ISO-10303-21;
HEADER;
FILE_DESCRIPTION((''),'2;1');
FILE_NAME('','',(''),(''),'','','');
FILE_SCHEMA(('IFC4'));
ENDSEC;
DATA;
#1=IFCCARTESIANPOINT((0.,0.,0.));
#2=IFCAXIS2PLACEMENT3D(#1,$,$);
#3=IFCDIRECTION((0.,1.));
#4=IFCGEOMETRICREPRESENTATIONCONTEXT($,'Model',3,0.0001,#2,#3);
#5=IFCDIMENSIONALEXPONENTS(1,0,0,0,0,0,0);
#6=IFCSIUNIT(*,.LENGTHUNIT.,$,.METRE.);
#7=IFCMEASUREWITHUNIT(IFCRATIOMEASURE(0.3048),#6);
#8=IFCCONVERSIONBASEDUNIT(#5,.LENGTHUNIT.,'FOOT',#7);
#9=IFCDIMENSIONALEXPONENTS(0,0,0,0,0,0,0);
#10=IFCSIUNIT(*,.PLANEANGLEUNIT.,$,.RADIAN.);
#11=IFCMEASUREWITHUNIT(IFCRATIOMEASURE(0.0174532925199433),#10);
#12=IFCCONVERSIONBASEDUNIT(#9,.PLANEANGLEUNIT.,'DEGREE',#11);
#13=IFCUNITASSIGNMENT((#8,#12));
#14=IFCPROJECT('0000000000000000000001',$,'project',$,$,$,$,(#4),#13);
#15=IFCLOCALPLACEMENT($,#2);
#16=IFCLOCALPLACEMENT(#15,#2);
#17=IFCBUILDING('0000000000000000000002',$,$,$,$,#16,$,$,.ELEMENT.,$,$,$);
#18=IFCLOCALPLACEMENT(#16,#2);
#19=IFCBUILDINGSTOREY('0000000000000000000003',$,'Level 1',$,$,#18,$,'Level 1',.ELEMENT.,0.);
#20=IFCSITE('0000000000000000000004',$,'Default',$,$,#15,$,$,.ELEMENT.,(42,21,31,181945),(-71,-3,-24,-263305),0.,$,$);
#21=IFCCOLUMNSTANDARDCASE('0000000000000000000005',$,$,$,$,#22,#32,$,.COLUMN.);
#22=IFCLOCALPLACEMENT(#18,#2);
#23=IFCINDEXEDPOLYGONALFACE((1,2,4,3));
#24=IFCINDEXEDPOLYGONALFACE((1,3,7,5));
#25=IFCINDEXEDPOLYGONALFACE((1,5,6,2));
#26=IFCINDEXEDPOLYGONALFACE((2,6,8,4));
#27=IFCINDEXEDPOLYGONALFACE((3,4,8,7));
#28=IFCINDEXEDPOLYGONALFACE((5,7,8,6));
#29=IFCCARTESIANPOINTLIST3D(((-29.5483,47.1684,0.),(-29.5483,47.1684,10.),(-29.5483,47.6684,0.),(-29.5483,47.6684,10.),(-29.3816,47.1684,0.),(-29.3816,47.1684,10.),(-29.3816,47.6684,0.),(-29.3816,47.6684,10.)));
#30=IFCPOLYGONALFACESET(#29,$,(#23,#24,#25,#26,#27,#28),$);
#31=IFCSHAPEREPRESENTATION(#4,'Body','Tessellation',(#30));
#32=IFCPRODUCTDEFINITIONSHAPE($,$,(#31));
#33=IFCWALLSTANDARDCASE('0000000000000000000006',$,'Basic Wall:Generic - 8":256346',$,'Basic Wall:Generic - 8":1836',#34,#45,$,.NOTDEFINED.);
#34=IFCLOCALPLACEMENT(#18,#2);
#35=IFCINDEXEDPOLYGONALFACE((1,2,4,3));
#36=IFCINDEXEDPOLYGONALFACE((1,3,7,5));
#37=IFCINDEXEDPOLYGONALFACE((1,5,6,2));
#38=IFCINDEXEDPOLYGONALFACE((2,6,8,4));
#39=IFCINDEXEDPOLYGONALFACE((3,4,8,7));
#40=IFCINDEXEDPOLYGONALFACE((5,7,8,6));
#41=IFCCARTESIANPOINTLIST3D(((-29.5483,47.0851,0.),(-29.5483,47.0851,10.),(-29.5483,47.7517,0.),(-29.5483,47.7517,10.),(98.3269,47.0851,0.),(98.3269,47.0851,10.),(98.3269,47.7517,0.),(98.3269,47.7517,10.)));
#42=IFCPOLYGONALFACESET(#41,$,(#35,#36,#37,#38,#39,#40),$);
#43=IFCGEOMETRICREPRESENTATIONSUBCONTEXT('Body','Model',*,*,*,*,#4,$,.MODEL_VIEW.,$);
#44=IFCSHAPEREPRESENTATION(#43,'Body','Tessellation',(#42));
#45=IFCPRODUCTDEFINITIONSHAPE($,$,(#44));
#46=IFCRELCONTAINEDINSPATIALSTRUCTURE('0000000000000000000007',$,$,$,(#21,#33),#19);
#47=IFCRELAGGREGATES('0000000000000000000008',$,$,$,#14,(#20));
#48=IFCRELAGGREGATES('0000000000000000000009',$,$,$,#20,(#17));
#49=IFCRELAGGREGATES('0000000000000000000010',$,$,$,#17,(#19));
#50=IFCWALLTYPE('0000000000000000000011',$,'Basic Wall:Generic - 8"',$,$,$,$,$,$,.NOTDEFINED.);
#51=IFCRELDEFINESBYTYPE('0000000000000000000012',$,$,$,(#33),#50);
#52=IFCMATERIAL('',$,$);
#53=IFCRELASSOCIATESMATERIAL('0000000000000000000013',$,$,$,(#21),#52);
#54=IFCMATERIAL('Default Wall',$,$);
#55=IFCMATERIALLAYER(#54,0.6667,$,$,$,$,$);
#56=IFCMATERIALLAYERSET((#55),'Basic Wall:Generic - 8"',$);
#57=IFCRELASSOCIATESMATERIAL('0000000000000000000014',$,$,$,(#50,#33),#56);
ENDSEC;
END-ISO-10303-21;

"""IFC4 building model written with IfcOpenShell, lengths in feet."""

from ifc_helpers import new_model, entity, si_unit, converted_unit, direction, frame, frame_2d, origin, place, context, subcontext, project, spatial, rectangle, extrude, material, layer, layer_set, layer_usage, type_object, element, save


model = new_model("IFC4")

# Units and contexts
model_context = context("Model", 3, precision=0.0001, world=origin(), true_north=direction((0.0, 1.0)))
body_context = subcontext(model_context, "Body", "Model", "MODEL_VIEW")
ifc_project = project(units=[converted_unit("LENGTHUNIT", "FOOT", entity("IfcRatioMeasure", 0.3048), si_unit("LENGTHUNIT", "METRE"), dimensions=[1, 0, 0, 0, 0, 0, 0]), converted_unit("PLANEANGLEUNIT", "DEGREE", entity("IfcRatioMeasure", 0.0174532925199433), si_unit("PLANEANGLEUNIT", "RADIAN"), dimensions=[0, 0, 0, 0, 0, 0, 0])], contexts=[model_context])

# Site, building, storey
site_placement = place(None, origin())
site = spatial("IfcSite", under=ifc_project, at=site_placement, Name="Default", CompositionType="ELEMENT", RefLatitude=(42, 21, 31, 181945), RefLongitude=(-71, -3, -24, -263305), RefElevation=0.0)
building_placement = place(site_placement, origin())
building = spatial("IfcBuilding", under=site, at=building_placement, CompositionType="ELEMENT")
storey_placement = place(building_placement, origin())
storey = spatial("IfcBuildingStorey", under=building, at=storey_placement, Name="Level 1", LongName="Level 1", CompositionType="ELEMENT", Elevation=0.0)

# Column
ifc_material_1 = material(Name="")
wall_placement = place(storey_placement, frame((-29.5483, 47.4184, 0.0)))
for number, where, z_axis, x_axis in (
    (1, (0.0833, 0.0, 0.0), (0.0, 0.0, 1.0), (1.0, 0.0, 0.0)),
):
    element("IfcColumnStandardCase", number, at=place(wall_placement, frame(where, z_axis=z_axis, x_axis=x_axis)), inside=storey, material=ifc_material_1, PredefinedType="COLUMN", context=model_context, shape_type="SweptSolid", body=[
        extrude(rectangle(XDim=0.1667, YDim=0.5), origin(), (0.0, 0.0, 1.0), 10.0),
    ])

# Wall
ifc_material_2 = material(Name="Default Wall")
ifc_layer = layer(ifc_material_2, 0.6667)
ifc_layer_set = layer_set([ifc_layer], Name="Basic Wall:Generic - 8\"")
ifc_layer_usage = layer_usage(ifc_layer_set, "AXIS2", "NEGATIVE", 0.3333)
wall_type = type_object("IfcWallType", Name="Basic Wall:Generic - 8\"", PredefinedType="NOTDEFINED", material=ifc_layer_set)
element("IfcWallStandardCase", 2, at=wall_placement, inside=storey, type_object=wall_type, material=ifc_layer_usage, Name="Basic Wall:Generic - 8\":256346", ObjectType="Basic Wall:Generic - 8\":1836", PredefinedType="NOTDEFINED", context=body_context, shape_type="SweptSolid", body=[
    extrude(rectangle(XDim=127.8752, YDim=0.6667, at=frame_2d((63.9376, 0.0), x_axis=(-1.0, 0.0))), origin(), (0.0, 0.0, 1.0), 10.0),
])

save(model, "model.ifc")
